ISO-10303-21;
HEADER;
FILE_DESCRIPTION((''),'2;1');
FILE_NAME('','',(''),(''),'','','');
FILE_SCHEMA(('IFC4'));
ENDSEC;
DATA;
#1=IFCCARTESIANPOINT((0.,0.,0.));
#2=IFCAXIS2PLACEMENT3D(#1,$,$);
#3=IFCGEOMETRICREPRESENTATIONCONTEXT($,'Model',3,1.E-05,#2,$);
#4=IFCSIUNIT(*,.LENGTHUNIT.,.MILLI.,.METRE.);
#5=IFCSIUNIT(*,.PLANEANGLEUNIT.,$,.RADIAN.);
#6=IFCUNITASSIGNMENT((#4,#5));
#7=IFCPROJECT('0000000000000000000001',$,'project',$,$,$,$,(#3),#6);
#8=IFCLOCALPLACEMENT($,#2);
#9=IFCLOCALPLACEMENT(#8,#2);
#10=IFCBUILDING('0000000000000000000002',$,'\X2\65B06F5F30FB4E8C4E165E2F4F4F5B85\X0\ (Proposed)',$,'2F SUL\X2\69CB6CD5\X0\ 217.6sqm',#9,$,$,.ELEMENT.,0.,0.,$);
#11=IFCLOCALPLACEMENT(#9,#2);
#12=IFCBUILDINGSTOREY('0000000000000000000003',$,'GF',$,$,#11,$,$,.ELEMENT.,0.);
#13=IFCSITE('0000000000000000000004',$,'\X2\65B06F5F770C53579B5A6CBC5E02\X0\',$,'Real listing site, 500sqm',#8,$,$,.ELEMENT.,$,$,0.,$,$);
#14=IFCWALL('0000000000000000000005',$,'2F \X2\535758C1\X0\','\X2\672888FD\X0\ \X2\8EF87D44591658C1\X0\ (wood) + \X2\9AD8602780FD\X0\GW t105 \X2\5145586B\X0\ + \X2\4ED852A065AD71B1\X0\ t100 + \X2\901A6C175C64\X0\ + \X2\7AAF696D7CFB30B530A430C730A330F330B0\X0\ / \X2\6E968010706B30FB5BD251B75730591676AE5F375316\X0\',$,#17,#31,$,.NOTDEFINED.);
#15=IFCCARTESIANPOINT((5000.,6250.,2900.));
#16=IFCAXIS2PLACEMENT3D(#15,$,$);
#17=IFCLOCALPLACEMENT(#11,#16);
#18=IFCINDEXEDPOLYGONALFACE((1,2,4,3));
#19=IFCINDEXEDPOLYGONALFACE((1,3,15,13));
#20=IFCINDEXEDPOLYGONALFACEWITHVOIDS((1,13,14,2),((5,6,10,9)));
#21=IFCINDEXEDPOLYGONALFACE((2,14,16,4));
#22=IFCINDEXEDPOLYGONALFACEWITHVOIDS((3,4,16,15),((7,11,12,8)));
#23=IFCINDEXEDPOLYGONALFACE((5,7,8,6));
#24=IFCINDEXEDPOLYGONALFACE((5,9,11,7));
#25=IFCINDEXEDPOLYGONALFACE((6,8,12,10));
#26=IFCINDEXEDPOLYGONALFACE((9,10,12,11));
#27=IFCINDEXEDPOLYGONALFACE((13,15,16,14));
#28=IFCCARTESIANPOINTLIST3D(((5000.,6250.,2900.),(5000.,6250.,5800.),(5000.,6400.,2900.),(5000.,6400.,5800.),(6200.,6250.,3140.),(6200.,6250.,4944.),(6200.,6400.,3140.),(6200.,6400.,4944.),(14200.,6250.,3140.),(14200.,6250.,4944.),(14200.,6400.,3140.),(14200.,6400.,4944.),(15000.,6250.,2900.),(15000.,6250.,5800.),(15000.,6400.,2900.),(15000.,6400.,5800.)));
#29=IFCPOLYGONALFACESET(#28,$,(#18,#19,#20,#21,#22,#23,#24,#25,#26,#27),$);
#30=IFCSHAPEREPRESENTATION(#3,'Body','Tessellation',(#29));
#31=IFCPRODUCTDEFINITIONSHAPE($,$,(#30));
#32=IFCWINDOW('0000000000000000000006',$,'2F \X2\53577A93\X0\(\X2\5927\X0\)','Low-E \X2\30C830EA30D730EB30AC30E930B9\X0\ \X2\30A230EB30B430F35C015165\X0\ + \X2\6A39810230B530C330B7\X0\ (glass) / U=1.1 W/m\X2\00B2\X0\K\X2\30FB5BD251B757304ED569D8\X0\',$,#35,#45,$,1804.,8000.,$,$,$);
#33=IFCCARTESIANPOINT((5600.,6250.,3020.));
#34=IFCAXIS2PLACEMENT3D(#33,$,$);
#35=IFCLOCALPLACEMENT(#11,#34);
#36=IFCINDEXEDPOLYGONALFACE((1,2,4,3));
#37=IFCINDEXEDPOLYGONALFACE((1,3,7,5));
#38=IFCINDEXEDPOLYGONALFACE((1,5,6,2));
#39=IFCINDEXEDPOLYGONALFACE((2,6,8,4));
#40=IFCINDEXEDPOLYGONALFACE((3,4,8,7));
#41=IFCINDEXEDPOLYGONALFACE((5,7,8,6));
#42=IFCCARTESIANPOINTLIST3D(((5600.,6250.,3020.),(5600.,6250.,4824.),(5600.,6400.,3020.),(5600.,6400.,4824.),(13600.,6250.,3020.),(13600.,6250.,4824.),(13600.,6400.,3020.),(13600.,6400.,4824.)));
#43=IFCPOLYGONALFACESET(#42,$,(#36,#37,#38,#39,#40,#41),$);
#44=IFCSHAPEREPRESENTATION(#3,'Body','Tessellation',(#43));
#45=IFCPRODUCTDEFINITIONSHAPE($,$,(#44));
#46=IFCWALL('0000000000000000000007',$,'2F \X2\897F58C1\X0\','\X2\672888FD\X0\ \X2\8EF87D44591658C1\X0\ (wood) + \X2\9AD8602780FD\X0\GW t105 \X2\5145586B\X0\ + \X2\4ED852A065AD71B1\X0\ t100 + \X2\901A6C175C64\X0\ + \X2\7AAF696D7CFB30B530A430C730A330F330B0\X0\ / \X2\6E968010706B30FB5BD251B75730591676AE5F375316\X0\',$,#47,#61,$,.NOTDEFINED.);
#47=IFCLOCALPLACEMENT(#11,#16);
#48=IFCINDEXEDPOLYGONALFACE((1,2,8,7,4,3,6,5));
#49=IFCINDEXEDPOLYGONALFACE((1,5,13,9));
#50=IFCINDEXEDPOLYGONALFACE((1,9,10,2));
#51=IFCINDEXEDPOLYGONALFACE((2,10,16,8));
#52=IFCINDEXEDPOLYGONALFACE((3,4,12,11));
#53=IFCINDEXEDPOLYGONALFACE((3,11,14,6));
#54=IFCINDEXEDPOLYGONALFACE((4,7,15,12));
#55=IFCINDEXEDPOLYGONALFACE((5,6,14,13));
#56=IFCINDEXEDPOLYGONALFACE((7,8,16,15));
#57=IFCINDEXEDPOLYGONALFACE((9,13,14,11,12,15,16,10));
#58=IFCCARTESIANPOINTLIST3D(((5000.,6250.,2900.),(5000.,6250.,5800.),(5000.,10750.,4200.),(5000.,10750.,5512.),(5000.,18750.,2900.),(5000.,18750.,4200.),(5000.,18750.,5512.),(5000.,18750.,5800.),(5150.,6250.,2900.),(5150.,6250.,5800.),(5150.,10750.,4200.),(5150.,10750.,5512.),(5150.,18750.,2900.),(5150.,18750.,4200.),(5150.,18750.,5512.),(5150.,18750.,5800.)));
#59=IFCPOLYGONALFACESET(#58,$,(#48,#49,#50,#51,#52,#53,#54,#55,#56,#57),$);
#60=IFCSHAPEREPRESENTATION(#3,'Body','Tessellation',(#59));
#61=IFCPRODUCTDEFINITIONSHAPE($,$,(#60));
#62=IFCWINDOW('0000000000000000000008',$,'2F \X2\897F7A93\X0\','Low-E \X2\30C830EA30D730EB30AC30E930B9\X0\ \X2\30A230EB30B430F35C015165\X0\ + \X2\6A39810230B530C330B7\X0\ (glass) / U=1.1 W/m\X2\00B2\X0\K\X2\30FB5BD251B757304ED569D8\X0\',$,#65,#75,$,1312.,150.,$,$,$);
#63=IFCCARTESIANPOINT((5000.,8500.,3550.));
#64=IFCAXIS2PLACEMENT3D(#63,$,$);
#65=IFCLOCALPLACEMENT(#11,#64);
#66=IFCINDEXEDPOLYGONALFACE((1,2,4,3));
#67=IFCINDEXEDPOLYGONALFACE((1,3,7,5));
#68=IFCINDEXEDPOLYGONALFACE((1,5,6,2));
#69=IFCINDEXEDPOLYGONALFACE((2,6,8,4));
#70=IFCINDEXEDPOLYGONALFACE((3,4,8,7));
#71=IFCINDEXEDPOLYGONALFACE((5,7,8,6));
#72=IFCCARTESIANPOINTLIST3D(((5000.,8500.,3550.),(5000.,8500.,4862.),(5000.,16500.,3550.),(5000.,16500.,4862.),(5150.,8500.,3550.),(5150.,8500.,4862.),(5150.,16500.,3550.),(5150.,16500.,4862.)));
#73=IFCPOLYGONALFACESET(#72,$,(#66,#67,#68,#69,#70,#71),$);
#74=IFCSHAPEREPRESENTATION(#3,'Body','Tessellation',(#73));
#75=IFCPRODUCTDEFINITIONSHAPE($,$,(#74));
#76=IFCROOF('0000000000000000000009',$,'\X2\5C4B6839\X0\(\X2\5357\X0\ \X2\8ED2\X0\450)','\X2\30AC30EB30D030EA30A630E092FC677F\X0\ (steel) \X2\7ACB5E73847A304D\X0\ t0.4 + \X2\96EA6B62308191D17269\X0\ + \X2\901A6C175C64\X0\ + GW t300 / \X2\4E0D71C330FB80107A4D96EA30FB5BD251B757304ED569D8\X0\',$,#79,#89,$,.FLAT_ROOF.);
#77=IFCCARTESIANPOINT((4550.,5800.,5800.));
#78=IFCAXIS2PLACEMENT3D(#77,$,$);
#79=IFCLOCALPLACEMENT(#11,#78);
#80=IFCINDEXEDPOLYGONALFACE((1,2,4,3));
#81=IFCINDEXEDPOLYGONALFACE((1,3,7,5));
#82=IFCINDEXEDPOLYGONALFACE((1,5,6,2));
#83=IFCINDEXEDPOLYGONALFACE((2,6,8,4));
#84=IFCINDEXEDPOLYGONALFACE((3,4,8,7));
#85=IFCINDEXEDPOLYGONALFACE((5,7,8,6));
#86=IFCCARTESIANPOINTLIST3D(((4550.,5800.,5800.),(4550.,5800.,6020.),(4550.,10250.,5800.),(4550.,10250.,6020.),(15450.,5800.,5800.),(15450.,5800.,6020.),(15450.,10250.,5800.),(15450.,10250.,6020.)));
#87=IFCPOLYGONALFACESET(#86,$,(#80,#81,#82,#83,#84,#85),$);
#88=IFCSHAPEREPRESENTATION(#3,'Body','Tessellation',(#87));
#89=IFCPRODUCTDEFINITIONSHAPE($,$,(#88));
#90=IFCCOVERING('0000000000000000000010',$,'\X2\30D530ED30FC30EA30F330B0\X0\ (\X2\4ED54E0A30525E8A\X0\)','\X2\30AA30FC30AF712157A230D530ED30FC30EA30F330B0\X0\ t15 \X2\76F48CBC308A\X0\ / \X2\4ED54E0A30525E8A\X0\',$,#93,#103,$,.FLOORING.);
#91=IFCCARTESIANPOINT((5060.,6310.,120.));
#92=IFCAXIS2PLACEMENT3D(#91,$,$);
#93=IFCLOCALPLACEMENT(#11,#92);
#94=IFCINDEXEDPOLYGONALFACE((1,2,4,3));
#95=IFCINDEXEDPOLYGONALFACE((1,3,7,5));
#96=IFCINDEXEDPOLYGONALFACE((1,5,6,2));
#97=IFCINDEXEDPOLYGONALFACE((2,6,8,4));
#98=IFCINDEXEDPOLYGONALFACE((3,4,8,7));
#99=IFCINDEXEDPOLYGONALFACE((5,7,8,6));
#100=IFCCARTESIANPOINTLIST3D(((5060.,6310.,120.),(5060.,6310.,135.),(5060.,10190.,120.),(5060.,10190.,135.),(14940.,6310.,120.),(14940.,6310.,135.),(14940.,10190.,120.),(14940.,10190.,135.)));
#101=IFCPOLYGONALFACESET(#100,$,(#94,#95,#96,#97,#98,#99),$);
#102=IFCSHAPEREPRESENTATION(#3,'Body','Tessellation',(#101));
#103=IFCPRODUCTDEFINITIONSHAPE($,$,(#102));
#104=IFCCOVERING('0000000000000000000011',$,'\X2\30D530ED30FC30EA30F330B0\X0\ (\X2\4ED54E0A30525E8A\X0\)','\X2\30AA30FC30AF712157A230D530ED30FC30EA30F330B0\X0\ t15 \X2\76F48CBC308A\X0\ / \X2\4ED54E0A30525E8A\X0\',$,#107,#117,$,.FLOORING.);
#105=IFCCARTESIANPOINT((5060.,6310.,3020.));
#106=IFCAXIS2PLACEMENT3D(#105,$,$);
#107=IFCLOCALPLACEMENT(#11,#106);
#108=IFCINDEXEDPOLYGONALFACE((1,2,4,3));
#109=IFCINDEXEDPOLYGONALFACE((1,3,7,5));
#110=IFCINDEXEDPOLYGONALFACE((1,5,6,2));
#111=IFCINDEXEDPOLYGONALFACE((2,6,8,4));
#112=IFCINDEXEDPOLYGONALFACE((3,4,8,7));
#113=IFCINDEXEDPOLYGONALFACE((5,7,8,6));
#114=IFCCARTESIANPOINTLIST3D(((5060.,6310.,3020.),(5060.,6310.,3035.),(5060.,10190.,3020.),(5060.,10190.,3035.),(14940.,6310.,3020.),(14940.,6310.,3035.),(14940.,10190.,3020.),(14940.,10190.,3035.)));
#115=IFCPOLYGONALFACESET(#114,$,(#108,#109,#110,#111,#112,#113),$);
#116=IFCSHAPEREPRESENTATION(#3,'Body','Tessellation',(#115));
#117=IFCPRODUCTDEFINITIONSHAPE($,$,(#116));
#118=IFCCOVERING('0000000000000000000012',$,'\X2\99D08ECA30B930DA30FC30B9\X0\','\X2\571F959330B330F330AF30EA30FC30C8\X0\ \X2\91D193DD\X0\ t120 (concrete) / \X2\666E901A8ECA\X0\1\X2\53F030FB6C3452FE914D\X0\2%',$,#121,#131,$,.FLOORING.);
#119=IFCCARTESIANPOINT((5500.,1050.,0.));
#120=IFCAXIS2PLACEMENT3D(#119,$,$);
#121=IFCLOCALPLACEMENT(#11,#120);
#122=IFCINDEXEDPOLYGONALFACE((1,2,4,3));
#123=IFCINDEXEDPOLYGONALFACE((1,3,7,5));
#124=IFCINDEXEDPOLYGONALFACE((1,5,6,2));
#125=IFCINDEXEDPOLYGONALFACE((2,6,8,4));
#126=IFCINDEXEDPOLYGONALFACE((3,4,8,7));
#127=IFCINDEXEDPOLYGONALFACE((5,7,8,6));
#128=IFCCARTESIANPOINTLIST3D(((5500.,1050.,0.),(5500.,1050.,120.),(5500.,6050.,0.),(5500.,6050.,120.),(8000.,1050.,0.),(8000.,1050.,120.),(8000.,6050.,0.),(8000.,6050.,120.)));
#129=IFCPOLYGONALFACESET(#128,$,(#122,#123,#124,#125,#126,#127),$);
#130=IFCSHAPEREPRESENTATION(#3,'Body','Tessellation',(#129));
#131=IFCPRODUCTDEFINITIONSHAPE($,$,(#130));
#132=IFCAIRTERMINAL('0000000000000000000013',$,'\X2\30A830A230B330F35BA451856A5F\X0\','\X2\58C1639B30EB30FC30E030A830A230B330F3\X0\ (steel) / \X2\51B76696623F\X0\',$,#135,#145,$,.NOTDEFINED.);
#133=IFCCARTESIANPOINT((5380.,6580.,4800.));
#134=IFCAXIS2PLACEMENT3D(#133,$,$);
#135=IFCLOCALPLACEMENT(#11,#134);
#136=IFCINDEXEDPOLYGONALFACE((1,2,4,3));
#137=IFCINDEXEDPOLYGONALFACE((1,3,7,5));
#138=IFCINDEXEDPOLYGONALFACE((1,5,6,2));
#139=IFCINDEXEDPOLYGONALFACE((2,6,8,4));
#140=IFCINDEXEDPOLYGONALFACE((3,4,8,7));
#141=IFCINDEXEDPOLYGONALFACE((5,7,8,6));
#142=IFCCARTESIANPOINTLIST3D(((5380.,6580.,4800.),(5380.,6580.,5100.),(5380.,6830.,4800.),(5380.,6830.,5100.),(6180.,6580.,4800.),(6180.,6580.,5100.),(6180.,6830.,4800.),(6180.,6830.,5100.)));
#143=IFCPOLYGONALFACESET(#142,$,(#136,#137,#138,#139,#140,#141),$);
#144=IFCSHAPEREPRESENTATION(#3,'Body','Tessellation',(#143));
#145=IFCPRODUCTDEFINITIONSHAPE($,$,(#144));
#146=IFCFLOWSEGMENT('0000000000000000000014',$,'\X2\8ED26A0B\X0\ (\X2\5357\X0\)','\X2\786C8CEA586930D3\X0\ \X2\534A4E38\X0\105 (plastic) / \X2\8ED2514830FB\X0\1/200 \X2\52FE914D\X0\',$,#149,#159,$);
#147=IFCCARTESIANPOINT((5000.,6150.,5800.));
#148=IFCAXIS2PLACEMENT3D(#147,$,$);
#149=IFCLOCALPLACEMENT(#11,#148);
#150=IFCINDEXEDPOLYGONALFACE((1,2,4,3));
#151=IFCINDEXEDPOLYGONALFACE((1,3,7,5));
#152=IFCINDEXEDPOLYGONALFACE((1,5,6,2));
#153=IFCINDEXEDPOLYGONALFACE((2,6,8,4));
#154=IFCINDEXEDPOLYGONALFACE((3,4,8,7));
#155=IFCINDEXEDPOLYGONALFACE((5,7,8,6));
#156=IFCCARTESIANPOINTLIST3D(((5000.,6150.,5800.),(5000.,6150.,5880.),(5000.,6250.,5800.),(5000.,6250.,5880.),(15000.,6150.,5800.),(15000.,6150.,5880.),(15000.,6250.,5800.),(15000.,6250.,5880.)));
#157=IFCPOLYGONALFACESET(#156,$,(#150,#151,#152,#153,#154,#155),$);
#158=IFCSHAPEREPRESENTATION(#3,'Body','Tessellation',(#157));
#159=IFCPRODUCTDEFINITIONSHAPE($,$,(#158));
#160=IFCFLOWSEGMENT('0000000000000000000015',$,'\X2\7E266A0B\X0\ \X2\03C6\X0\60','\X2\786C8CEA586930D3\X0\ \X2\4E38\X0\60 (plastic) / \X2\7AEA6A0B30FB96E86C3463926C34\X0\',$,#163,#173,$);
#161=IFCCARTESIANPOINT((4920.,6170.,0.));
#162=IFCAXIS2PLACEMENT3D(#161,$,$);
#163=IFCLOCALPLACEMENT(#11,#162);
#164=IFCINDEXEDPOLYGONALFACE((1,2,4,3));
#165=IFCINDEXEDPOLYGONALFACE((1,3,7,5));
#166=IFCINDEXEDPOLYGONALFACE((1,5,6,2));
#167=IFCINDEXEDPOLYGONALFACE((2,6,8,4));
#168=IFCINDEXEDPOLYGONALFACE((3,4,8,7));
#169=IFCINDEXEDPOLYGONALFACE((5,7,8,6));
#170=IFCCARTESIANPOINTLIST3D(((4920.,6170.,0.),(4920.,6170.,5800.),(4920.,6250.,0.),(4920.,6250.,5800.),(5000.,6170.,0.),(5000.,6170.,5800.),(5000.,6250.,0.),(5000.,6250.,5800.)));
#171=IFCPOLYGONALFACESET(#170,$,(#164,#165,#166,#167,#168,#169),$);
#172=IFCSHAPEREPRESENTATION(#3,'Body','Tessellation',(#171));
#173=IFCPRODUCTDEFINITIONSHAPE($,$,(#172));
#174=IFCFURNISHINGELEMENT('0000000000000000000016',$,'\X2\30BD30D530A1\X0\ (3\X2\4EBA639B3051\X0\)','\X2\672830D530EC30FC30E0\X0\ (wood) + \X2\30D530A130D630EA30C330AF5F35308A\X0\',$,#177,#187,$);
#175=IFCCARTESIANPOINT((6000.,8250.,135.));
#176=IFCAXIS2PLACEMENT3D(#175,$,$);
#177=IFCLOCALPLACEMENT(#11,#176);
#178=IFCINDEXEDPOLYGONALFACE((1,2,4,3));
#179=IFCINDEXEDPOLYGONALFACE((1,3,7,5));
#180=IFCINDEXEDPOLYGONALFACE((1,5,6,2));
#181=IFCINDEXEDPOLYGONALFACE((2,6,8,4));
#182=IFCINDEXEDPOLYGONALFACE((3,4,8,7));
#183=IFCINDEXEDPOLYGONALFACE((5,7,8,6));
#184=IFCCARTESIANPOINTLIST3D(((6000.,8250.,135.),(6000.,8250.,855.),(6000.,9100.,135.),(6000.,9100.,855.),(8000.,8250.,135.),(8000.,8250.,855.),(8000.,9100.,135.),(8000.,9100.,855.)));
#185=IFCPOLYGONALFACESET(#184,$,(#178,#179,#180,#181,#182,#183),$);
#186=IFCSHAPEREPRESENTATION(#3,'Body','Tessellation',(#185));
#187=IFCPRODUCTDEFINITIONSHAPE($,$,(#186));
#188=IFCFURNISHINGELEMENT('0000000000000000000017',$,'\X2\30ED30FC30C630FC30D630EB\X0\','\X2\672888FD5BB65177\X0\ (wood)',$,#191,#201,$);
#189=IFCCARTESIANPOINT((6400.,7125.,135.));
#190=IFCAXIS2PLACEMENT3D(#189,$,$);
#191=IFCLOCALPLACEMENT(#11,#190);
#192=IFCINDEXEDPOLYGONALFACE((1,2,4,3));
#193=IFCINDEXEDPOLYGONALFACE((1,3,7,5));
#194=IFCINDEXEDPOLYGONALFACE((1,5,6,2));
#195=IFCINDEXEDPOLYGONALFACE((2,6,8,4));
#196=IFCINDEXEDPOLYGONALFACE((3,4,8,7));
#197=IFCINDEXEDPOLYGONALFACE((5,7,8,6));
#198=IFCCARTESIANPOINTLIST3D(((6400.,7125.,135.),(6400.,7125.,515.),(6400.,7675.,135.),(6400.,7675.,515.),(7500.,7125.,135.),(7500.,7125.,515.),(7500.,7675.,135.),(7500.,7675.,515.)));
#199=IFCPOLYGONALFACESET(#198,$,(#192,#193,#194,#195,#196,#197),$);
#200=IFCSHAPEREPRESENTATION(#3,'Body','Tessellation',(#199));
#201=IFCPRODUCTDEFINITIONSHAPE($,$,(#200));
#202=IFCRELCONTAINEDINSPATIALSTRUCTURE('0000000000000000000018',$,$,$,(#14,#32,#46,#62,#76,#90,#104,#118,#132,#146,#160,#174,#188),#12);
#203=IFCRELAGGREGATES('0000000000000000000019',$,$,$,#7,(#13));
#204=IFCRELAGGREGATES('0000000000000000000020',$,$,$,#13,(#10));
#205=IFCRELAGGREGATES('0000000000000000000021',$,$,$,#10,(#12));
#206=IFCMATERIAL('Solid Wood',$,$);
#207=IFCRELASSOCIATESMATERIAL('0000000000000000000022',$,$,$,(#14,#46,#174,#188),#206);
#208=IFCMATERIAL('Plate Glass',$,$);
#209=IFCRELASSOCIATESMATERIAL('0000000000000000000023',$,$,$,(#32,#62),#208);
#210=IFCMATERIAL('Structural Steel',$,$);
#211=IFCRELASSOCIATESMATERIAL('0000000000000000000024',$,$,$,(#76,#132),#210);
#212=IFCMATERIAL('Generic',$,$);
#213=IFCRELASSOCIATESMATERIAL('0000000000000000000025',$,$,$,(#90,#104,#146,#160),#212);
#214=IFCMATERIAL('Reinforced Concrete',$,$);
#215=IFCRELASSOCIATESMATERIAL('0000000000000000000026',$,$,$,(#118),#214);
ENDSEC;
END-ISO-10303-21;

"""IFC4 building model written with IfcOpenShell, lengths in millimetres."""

from ifc_helpers import new_model, si_unit, frame, frame_2d, origin, place, context, project, spatial, rectangle, extrude, material, element, fill, save


model = new_model("IFC4")

# Units and contexts
model_context = context("Model", 3, precision=1e-05, world=origin())
ifc_project = project(units=[si_unit("LENGTHUNIT", "METRE", prefix="MILLI"), si_unit("PLANEANGLEUNIT", "RADIAN")], contexts=[model_context])

# Site, building, storey
site_placement = place(None, origin())
site = spatial("IfcSite", under=ifc_project, at=site_placement, Name="新潟県南魚沼市", ObjectType="Real listing site, 500sqm", CompositionType="ELEMENT", RefElevation=0.0)
building_placement = place(site_placement, origin())
building = spatial("IfcBuilding", under=site, at=building_placement, Name="新潟・二世帯住宅 (Proposed)", ObjectType="2F SUL構法 217.6sqm", CompositionType="ELEMENT", ElevationOfRefHeight=0.0, ElevationOfTerrain=0.0)
storey_placement = place(building_placement, origin())
storey = spatial("IfcBuildingStorey", under=building, at=storey_placement, Name="GF", CompositionType="ELEMENT", Elevation=0.0)

# Shared definitions
ifc_material_1 = material(Name="Solid Wood")

# Shared definitions
ifc_material_2 = material(Name="Reinforced Concrete")

# Shared definitions
ifc_material_3 = material(Name="Plate Glass")

# Walls, openings, windows
wall_1_placement = place(storey_placement, frame((5000.0, 6250.0, 2900.0)))
wall_1 = element("IfcWall", 1, at=wall_1_placement, inside=storey, material=ifc_material_1, Name="2F 南壁", Description="木製 軸組外壁 (wood) + 高性能GW t105 充填 + 付加断熱 t100 + 通気層 + 窯業系サイディング / 準耐火・寒冷地外皮強化", PredefinedType="NOTDEFINED", context=model_context, shape_type="SweptSolid", body=[
    extrude(rectangle(XDim=10000.0, YDim=150.0, at=frame_2d((5000.0, 75.0))), frame((5000.0, 6250.0, 2900.0)), (0.0, 0.0, 1.0), 2900.0),
])
opening_1_placement = place(storey_placement, frame((5600.0, 6250.0, 3020.0)))
opening_1 = element("IfcOpeningElement", 2, at=opening_1_placement, cuts=wall_1, PredefinedType="NOTDEFINED", context=model_context, shape_type="SweptSolid", body=[
    extrude(rectangle(XDim=8000.0, YDim=150.0, at=frame_2d((4000.0, 75.0))), frame((5600.0, 6250.0, 3020.0)), (0.0, 0.0, 1.0), 1804.0),
])
window_1_placement = place(storey_placement, frame((5600.0, 6250.0, 3020.0)))
window_1 = element("IfcWindow", 3, at=window_1_placement, inside=storey, material=ifc_material_3, Name="2F 南窓(大)", Description="Low-E トリプルガラス アルゴン封入 + 樹脂サッシ (glass) / U=1.1 W/m²K・寒冷地仕様", OverallHeight=1804.0, OverallWidth=8000.0, context=model_context, shape_type="SweptSolid", body=[
    extrude(rectangle(XDim=8000.0, YDim=150.0, at=frame_2d((4000.0, 75.0))), frame((5600.0, 6250.0, 3020.0)), (0.0, 0.0, 1.0), 1804.0),
])
fill(opening_1, window_1)
wall_2_placement = place(storey_placement, frame((5000.0, 6250.0, 2900.0)))
wall_2 = element("IfcWall", 4, at=wall_2_placement, inside=storey, material=ifc_material_1, Name="2F 西壁", Description="木製 軸組外壁 (wood) + 高性能GW t105 充填 + 付加断熱 t100 + 通気層 + 窯業系サイディング / 準耐火・寒冷地外皮強化", PredefinedType="NOTDEFINED", context=model_context, shape_type="SweptSolid", body=[
    extrude(rectangle(XDim=150.0, YDim=12500.0, at=frame_2d((75.0, 6250.0))), frame((5000.0, 6250.0, 2900.0)), (0.0, 0.0, 1.0), 2900.0),
])
opening_2_placement = place(storey_placement, frame((5000.0, 8500.0, 3550.0)))
opening_2 = element("IfcOpeningElement", 5, at=opening_2_placement, cuts=wall_2, PredefinedType="NOTDEFINED", context=model_context, shape_type="SweptSolid", body=[
    extrude(rectangle(XDim=150.0, YDim=8000.0, at=frame_2d((75.0, 4000.0))), frame((5000.0, 8500.0, 3550.0)), (0.0, 0.0, 1.0), 1312.0),
])
window_2_placement = place(storey_placement, frame((5000.0, 8500.0, 3550.0)))
window_2 = element("IfcWindow", 6, at=window_2_placement, inside=storey, material=ifc_material_3, Name="2F 西窓", Description="Low-E トリプルガラス アルゴン封入 + 樹脂サッシ (glass) / U=1.1 W/m²K・寒冷地仕様", OverallHeight=1312.0, OverallWidth=150.0, context=model_context, shape_type="SweptSolid", body=[
    extrude(rectangle(XDim=150.0, YDim=8000.0, at=frame_2d((75.0, 4000.0))), frame((5000.0, 8500.0, 3550.0)), (0.0, 0.0, 1.0), 1312.0),
])
fill(opening_2, window_2)

# Roof
ifc_material_4 = material(Name="Structural Steel")
for number, where, name in (
    (7, (4550.0, 5800.0, 5800.0), "屋根(南 軒450)"),
):
    element("IfcRoof", number, at=place(storey_placement, frame(where)), inside=storey, material=ifc_material_4, Name=name, Description="ガルバリウム鋼板 (steel) 立平葺き t0.4 + 雪止め金物 + 通気層 + GW t300 / 不燃・耐積雪・寒冷地仕様", PredefinedType="FLAT_ROOF", context=model_context, shape_type="SweptSolid", body=[
        extrude(rectangle(XDim=10900.0, YDim=4450.0, at=frame_2d((5450.0, 2225.0))), frame((4550.0, 5800.0, 5800.0)), (0.0, 0.0, 1.0), 220.0),
    ])

# Coverings
ifc_material_5 = material(Name="Generic")
covering_1_placement = place(storey_placement, frame((5060.0, 6310.0, 120.0)))
element("IfcCovering", 8, at=covering_1_placement, inside=storey, material=ifc_material_5, Name="フローリング (仕上げ床)", Description="オーク無垢フローリング t15 直貼り / 仕上げ床", PredefinedType="FLOORING", context=model_context, shape_type="SweptSolid", body=[
    extrude(rectangle(XDim=9880.0, YDim=3880.0, at=frame_2d((4940.0, 1940.0))), frame((5060.0, 6310.0, 120.0)), (0.0, 0.0, 1.0), 15.0),
])
covering_2_placement = place(storey_placement, frame((5060.0, 6310.0, 3020.0)))
element("IfcCovering", 9, at=covering_2_placement, inside=storey, material=ifc_material_5, Name="フローリング (仕上げ床)", Description="オーク無垢フローリング t15 直貼り / 仕上げ床", PredefinedType="FLOORING", context=model_context, shape_type="SweptSolid", body=[
    extrude(rectangle(XDim=9880.0, YDim=3880.0, at=frame_2d((4940.0, 1940.0))), frame((5060.0, 6310.0, 3020.0)), (0.0, 0.0, 1.0), 15.0),
])
covering_3_placement = place(storey_placement, frame((5500.0, 1050.0, 0.0)))
element("IfcCovering", 10, at=covering_3_placement, inside=storey, material=ifc_material_2, Name="駐車スペース", Description="土間コンクリート 金鏝 t120 (concrete) / 普通車1台・水勾配2%", PredefinedType="FLOORING", context=model_context, shape_type="SweptSolid", body=[
    extrude(rectangle(XDim=2500.0, YDim=5000.0, at=frame_2d((1250.0, 2500.0))), frame((5500.0, 1050.0, 0.0)), (0.0, 0.0, 1.0), 120.0),
])

# Air terminal
air_terminal_placement = place(storey_placement, frame((5380.0, 6580.0, 4800.0)))
element("IfcAirTerminal", 11, at=air_terminal_placement, inside=storey, material=ifc_material_4, Name="エアコン室内機", Description="壁掛ルームエアコン (steel) / 冷暖房", PredefinedType="NOTDEFINED", context=model_context, shape_type="SweptSolid", body=[
    extrude(rectangle(XDim=800.0, YDim=250.0, at=frame_2d((400.0, 125.0))), frame((5380.0, 6580.0, 4800.0)), (0.0, 0.0, 1.0), 300.0),
])

# Flow segments
flow_segment_1_placement = place(storey_placement, frame((5000.0, 6150.0, 5800.0)))
element("IfcFlowSegment", 12, at=flow_segment_1_placement, inside=storey, material=ifc_material_5, Name="軒樋 (南)", Description="硬質塩ビ 半丸105 (plastic) / 軒先・1/200 勾配", context=model_context, shape_type="SweptSolid", body=[
    extrude(rectangle(XDim=10000.0, YDim=100.0, at=frame_2d((5000.0, 50.0))), frame((5000.0, 6150.0, 5800.0)), (0.0, 0.0, 1.0), 80.0),
])
flow_segment_2_placement = place(storey_placement, frame((4920.0, 6170.0, 0.0)))
element("IfcFlowSegment", 13, at=flow_segment_2_placement, inside=storey, material=ifc_material_5, Name="縦樋 φ60", Description="硬質塩ビ 丸60 (plastic) / 竪樋・雨水排水", context=model_context, shape_type="SweptSolid", body=[
    extrude(rectangle(XDim=80.0, YDim=80.0, at=frame_2d((40.0, 40.0))), frame((4920.0, 6170.0, 0.0)), (0.0, 0.0, 1.0), 5800.0),
])

# Furnishing elements
furnishing_1_placement = place(storey_placement, frame((6000.0, 8250.0, 135.0)))
element("IfcFurnishingElement", 14, at=furnishing_1_placement, inside=storey, material=ifc_material_1, Name="ソファ (3人掛け)", Description="木フレーム (wood) + ファブリック張り", context=model_context, shape_type="SweptSolid", body=[
    extrude(rectangle(XDim=2000.0, YDim=850.0, at=frame_2d((1000.0, 425.0))), frame((6000.0, 8250.0, 135.0)), (0.0, 0.0, 1.0), 720.0),
])
furnishing_2_placement = place(storey_placement, frame((6400.0, 7125.0, 135.0)))
element("IfcFurnishingElement", 15, at=furnishing_2_placement, inside=storey, material=ifc_material_1, Name="ローテーブル", Description="木製家具 (wood)", context=model_context, shape_type="SweptSolid", body=[
    extrude(rectangle(XDim=1100.0, YDim=550.0, at=frame_2d((550.0, 275.0))), frame((6400.0, 7125.0, 135.0)), (0.0, 0.0, 1.0), 380.0),
])

save(model, "model.ifc")
